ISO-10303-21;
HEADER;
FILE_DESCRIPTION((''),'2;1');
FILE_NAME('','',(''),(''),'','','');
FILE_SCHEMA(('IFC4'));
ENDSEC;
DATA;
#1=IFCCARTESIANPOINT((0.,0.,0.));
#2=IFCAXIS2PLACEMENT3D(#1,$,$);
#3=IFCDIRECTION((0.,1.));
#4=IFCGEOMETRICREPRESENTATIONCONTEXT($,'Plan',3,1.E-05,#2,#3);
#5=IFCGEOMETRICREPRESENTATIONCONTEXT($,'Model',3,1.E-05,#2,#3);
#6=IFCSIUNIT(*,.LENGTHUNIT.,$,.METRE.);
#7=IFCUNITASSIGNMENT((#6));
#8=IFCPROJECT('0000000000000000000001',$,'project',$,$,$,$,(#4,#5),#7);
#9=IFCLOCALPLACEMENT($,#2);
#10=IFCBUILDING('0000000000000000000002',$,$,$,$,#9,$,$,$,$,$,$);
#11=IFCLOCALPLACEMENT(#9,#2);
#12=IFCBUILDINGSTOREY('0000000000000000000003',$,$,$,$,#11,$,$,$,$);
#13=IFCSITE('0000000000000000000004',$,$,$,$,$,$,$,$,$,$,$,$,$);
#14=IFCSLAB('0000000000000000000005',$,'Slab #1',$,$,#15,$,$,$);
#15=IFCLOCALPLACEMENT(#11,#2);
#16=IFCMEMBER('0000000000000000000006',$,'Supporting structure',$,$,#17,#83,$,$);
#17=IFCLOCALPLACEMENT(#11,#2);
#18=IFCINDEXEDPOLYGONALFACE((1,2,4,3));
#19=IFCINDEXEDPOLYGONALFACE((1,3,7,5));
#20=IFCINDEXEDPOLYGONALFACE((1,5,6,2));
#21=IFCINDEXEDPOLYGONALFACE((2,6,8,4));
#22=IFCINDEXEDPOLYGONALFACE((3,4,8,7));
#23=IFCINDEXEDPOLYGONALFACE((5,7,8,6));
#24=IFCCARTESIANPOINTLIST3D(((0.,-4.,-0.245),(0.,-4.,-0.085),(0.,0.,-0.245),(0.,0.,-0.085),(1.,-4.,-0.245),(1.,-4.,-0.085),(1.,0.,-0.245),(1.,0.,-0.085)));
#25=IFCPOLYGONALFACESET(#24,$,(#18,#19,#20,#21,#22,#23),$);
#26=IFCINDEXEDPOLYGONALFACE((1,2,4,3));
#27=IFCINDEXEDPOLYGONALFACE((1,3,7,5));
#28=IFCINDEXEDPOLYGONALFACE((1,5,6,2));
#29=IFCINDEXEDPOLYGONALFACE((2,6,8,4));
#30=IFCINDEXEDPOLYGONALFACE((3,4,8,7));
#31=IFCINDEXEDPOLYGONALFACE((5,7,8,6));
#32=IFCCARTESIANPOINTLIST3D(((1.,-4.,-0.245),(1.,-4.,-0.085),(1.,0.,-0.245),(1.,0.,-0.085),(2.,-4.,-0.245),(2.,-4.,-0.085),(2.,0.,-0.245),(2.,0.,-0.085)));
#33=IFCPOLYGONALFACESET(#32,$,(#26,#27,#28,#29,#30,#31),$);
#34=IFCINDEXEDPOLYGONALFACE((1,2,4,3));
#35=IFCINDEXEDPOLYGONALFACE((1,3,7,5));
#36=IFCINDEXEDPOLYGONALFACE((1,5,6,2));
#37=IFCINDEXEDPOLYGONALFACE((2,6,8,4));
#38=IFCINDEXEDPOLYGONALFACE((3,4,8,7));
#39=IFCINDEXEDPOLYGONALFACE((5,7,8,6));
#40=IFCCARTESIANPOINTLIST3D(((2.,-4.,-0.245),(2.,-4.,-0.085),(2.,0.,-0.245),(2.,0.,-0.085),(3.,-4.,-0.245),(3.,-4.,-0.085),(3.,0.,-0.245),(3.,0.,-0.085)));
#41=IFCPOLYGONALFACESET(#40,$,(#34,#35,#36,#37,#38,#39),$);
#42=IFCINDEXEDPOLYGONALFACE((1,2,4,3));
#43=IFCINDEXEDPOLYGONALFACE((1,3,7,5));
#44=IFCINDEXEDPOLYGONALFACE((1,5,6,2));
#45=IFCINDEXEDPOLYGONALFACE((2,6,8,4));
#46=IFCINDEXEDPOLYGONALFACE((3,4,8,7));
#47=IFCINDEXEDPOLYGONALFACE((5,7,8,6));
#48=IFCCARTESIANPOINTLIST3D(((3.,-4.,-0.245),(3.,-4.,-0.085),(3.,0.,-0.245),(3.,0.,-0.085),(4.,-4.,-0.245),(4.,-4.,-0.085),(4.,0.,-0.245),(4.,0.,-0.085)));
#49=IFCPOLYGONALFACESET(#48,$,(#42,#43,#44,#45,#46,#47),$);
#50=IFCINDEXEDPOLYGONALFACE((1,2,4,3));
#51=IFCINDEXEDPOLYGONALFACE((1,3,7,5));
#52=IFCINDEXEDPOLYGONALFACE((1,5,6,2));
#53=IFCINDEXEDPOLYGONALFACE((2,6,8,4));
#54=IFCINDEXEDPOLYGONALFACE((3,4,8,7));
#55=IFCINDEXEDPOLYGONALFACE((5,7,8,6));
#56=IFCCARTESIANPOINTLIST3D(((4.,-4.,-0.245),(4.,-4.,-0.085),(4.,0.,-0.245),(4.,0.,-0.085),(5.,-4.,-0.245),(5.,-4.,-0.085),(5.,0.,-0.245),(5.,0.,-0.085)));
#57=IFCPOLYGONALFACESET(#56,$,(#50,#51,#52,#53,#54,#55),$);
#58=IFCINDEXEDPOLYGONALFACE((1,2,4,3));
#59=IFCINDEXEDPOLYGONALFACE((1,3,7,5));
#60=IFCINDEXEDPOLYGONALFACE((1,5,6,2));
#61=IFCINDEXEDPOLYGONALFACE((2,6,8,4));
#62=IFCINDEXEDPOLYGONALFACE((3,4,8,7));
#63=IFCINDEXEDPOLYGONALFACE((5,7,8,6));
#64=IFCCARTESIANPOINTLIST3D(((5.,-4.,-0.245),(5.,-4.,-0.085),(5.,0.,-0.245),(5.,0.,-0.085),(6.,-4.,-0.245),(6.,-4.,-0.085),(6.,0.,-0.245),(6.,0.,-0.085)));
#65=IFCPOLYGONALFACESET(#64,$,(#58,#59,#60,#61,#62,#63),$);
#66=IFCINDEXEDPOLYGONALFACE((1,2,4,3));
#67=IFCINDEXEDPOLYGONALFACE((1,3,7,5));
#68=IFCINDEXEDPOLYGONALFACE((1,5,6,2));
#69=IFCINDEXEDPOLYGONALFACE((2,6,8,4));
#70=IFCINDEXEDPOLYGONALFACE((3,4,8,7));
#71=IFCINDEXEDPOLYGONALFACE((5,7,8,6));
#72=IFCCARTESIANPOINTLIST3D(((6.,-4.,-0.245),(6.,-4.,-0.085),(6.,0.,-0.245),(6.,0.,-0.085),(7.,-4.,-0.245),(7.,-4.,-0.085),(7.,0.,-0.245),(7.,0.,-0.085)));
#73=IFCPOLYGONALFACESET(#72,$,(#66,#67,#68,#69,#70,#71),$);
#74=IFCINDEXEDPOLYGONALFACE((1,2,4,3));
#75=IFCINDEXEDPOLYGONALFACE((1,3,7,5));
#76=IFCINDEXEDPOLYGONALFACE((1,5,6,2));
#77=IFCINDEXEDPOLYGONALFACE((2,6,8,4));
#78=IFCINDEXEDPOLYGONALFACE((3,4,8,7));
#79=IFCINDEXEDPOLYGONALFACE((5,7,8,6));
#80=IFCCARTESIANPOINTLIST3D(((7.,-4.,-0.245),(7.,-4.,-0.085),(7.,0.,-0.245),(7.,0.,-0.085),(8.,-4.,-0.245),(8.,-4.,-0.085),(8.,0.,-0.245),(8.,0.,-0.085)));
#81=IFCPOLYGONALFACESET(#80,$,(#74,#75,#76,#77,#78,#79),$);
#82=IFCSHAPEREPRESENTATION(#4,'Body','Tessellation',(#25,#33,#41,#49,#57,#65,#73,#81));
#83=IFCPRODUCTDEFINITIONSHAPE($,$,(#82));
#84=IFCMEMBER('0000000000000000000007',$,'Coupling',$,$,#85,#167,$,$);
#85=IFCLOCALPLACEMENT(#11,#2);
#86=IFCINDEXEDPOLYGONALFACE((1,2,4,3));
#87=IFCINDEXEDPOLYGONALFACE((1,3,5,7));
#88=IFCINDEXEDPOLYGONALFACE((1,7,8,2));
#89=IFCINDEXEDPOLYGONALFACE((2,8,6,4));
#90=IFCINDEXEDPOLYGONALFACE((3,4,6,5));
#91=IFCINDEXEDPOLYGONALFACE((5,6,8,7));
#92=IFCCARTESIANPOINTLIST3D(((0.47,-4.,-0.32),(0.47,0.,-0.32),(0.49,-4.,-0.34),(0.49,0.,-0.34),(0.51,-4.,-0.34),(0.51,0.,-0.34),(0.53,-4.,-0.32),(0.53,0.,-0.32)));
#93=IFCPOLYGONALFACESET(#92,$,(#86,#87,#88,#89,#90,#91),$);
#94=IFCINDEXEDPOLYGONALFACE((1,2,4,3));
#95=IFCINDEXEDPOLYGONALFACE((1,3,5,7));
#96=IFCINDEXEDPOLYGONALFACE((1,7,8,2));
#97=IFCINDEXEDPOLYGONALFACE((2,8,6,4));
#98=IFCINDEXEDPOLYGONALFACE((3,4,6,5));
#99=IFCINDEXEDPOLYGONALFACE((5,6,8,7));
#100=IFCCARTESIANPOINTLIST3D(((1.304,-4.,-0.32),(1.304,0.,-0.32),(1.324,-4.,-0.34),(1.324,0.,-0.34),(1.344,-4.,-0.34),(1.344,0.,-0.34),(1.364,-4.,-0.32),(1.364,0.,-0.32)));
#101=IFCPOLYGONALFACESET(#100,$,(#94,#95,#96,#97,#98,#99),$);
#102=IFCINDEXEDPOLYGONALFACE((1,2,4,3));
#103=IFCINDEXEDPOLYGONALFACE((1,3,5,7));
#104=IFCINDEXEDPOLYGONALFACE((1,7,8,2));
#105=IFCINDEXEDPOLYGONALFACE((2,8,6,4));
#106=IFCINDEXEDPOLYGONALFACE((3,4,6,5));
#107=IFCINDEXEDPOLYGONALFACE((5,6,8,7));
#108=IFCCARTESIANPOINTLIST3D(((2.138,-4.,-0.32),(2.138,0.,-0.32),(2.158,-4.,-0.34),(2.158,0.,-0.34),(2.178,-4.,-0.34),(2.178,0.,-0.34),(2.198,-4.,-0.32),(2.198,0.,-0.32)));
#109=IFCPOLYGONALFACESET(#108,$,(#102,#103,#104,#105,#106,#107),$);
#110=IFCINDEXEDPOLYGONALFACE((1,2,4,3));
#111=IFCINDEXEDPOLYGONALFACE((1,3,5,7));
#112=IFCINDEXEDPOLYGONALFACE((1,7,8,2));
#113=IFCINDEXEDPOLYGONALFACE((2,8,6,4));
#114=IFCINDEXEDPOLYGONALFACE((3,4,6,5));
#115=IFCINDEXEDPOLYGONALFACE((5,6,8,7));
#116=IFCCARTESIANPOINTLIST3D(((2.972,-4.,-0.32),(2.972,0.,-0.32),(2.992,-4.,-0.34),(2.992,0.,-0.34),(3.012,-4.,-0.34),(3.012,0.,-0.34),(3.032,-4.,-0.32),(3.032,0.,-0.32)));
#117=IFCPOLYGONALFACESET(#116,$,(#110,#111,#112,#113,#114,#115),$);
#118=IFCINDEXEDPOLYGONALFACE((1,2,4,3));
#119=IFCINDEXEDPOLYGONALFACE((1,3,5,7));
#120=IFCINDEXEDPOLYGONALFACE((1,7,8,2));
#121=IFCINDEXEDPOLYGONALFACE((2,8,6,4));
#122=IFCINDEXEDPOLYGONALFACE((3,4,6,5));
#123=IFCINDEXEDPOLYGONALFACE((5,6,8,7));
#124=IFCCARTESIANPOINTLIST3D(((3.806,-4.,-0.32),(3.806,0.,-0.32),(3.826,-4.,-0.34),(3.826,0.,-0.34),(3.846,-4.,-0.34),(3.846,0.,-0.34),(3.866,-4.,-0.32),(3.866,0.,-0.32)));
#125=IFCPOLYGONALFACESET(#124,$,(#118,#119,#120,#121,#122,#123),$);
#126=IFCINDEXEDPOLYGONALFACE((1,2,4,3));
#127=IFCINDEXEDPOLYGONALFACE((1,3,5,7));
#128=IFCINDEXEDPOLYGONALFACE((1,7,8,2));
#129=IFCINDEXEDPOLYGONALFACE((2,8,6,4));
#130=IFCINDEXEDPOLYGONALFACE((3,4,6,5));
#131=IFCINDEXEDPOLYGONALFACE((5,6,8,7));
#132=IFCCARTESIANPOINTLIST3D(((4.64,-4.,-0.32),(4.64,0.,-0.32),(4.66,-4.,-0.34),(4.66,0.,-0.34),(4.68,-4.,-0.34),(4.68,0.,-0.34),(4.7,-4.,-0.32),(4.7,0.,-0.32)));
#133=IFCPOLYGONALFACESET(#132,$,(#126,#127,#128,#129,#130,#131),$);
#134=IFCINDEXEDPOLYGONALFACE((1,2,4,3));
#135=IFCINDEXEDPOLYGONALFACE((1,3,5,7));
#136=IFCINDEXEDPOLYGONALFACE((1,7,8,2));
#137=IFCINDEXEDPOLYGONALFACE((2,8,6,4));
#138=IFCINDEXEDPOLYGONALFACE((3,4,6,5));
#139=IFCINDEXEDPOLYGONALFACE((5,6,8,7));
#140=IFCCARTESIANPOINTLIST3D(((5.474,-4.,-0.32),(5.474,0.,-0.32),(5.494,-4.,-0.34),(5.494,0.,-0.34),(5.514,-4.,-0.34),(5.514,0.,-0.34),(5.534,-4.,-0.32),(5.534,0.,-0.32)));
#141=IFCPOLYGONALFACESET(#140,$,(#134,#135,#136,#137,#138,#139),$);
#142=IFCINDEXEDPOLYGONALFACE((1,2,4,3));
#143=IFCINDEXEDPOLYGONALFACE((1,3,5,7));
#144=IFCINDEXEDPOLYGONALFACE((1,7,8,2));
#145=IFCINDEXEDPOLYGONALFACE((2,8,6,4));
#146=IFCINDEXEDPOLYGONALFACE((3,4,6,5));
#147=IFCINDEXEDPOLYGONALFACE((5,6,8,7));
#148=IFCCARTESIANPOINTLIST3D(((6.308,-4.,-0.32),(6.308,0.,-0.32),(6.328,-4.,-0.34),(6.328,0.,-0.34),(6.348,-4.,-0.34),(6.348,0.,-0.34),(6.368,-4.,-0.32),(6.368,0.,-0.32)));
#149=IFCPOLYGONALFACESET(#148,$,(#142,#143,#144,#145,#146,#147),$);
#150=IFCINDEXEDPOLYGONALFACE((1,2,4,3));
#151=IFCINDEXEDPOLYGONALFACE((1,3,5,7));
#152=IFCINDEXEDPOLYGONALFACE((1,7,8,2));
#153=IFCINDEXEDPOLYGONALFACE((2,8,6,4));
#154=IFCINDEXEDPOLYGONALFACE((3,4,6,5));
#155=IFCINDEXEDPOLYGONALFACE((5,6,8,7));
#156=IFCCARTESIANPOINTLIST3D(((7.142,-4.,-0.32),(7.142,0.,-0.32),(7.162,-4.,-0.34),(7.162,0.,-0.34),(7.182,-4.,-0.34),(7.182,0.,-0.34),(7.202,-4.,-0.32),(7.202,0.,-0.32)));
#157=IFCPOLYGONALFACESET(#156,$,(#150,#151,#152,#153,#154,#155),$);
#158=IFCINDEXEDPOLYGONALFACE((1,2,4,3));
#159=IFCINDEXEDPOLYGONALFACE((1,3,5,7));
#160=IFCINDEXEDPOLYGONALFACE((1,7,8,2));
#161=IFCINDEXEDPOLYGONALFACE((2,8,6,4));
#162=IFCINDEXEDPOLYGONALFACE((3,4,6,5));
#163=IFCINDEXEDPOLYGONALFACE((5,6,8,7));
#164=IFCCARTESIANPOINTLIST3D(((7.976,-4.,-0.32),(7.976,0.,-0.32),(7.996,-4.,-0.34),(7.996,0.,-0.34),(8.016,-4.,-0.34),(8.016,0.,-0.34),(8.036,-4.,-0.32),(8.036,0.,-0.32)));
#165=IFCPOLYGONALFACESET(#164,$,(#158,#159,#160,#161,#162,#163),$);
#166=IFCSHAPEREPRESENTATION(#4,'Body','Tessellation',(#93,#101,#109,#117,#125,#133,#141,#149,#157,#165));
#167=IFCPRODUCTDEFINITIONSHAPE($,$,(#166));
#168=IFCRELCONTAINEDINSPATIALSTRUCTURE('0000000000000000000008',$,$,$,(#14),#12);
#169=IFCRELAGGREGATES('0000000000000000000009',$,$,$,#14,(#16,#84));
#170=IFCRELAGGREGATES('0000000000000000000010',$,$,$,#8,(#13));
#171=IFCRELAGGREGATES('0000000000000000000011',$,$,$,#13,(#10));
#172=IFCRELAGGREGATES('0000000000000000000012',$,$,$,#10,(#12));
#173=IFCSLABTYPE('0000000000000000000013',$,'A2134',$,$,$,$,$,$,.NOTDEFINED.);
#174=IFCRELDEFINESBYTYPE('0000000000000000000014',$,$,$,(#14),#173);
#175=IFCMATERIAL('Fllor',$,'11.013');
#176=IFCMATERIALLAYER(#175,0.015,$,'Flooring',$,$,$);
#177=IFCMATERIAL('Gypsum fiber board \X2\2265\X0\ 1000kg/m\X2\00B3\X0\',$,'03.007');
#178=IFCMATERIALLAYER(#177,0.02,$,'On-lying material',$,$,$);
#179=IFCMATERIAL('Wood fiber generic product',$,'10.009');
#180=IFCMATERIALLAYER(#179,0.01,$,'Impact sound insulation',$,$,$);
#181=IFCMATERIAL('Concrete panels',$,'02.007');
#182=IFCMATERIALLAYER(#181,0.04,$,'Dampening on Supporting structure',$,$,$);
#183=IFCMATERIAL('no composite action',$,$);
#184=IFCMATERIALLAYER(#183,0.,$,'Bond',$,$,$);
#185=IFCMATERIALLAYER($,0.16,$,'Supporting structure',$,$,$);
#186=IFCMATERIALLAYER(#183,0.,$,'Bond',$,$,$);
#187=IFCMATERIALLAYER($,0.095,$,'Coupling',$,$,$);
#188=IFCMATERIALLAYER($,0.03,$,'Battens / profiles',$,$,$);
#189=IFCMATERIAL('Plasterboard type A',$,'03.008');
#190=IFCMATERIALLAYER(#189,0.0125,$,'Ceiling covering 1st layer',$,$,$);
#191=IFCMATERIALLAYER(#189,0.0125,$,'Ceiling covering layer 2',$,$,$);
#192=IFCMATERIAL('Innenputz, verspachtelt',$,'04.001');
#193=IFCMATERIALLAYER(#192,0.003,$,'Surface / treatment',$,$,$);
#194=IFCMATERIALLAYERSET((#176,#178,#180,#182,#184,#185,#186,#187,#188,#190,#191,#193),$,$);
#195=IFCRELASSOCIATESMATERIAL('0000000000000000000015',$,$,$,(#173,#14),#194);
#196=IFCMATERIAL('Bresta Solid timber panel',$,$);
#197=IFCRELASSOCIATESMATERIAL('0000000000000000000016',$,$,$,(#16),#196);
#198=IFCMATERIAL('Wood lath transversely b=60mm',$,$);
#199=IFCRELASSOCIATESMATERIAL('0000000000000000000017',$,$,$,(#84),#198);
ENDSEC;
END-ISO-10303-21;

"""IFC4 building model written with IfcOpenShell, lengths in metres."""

from ifc_helpers import new_model, si_unit, direction, frame, frame_2d, origin, place, context, project, spatial, polyline, rectangle, outline, extrude, material, layer, layer_set, type_object, element, aggregate, save


model = new_model("IFC4")

# Units and contexts
plan_context = context("Plan", 3, precision=1e-05, world=origin(), true_north=direction((0.0, 1.0)))
model_context = context("Model", 3, precision=1e-05, world=origin(), true_north=direction((0.0, 1.0)))
ifc_project = project(units=[si_unit("LENGTHUNIT", "METRE")], contexts=[plan_context, model_context])

# Site, building, storey
site = spatial("IfcSite", under=ifc_project)
building_placement = place(None, origin())
building = spatial("IfcBuilding", under=site, at=building_placement)
storey_placement = place(building_placement, origin())
storey = spatial("IfcBuildingStorey", under=building, at=storey_placement)

# Slab, members
ifc_material_1 = material(Name="Fllor", Category="11.013")
ifc_layer_1 = layer(ifc_material_1, 0.015, Name="Flooring")
ifc_material_2 = material(Name="Gypsum fiber board ≥ 1000kg/m³", Category="03.007")
ifc_layer_2 = layer(ifc_material_2, 0.02, Name="On-lying material")
ifc_material_3 = material(Name="Wood fiber generic product", Category="10.009")
ifc_layer_3 = layer(ifc_material_3, 0.01, Name="Impact sound insulation")
ifc_material_4 = material(Name="Concrete panels", Category="02.007")
ifc_layer_4 = layer(ifc_material_4, 0.04, Name="Dampening on Supporting structure")
ifc_material_5 = material(Name="no composite action")
ifc_layer_5 = layer(ifc_material_5, 0.0, Name="Bond")
ifc_layer_6 = layer(None, 0.16, Name="Supporting structure")
ifc_layer_7 = layer(ifc_material_5, 0.0, Name="Bond")
ifc_layer_8 = layer(None, 0.095, Name="Coupling")
ifc_layer_9 = layer(None, 0.03, Name="Battens / profiles")
ifc_material_6 = material(Name="Plasterboard type A", Category="03.008")
ifc_layer_10 = layer(ifc_material_6, 0.0125, Name="Ceiling covering 1st layer")
ifc_layer_11 = layer(ifc_material_6, 0.0125, Name="Ceiling covering layer 2")
ifc_material_7 = material(Name="Innenputz, verspachtelt", Category="04.001")
ifc_layer_12 = layer(ifc_material_7, 0.003, Name="Surface / treatment")
ifc_layer_set = layer_set([ifc_layer_1, ifc_layer_2, ifc_layer_3, ifc_layer_4, ifc_layer_5, ifc_layer_6, ifc_layer_7, ifc_layer_8, ifc_layer_9, ifc_layer_10, ifc_layer_11, ifc_layer_12])
slab_type = type_object("IfcSlabType", Name="A2134", PredefinedType="NOTDEFINED", material=ifc_layer_set)
slab_placement = place(None, frame((0.0, 0.0, 0.0), z_axis=(0.0, 0.0, -1.0), x_axis=(1.0, 0.0, 0.0)))
slab = element("IfcSlab", 1, at=slab_placement, inside=storey, type_object=slab_type, material=ifc_layer_set, Name="Slab #1")
ifc_material_8 = material(Name="Bresta Solid timber panel")
member_1_placement = place(slab_placement, origin())
member_1 = element("IfcMember", 2, at=member_1_placement, material=ifc_material_8, Name="Supporting structure", context=plan_context, shape_type="SweptSolid", body=[
    extrude(rectangle(XDim=1.0, YDim=0.16, at=frame_2d((0.5, 0.08), x_axis=(1.0, 0.0))), frame((0.0, 4.0, 0.085), z_axis=(0.0, -1.0, 0.0), x_axis=(1.0, 0.0, 0.0)), (0.0, 0.0, 1.0), 4.0),
    extrude(rectangle(XDim=1.0, YDim=0.16, at=frame_2d((0.5, 0.08), x_axis=(1.0, 0.0))), frame((1.0, 4.0, 0.085), z_axis=(0.0, -1.0, 0.0), x_axis=(1.0, 0.0, 0.0)), (0.0, 0.0, 1.0), 4.0),
    extrude(rectangle(XDim=1.0, YDim=0.16, at=frame_2d((0.5, 0.08), x_axis=(1.0, 0.0))), frame((2.0, 4.0, 0.085), z_axis=(0.0, -1.0, 0.0), x_axis=(1.0, 0.0, 0.0)), (0.0, 0.0, 1.0), 4.0),
    extrude(rectangle(XDim=1.0, YDim=0.16, at=frame_2d((0.5, 0.08), x_axis=(1.0, 0.0))), frame((3.0, 4.0, 0.085), z_axis=(0.0, -1.0, 0.0), x_axis=(1.0, 0.0, 0.0)), (0.0, 0.0, 1.0), 4.0),
    extrude(rectangle(XDim=1.0, YDim=0.16, at=frame_2d((0.5, 0.08), x_axis=(1.0, 0.0))), frame((4.0, 4.0, 0.085), z_axis=(0.0, -1.0, 0.0), x_axis=(1.0, 0.0, 0.0)), (0.0, 0.0, 1.0), 4.0),
    extrude(rectangle(XDim=1.0, YDim=0.16, at=frame_2d((0.5, 0.08), x_axis=(1.0, 0.0))), frame((5.0, 4.0, 0.085), z_axis=(0.0, -1.0, 0.0), x_axis=(1.0, 0.0, 0.0)), (0.0, 0.0, 1.0), 4.0),
    extrude(rectangle(XDim=1.0, YDim=0.16, at=frame_2d((0.5, 0.08), x_axis=(1.0, 0.0))), frame((6.0, 4.0, 0.085), z_axis=(0.0, -1.0, 0.0), x_axis=(1.0, 0.0, 0.0)), (0.0, 0.0, 1.0), 4.0),
    extrude(rectangle(XDim=1.0, YDim=0.16, at=frame_2d((0.5, 0.08), x_axis=(1.0, 0.0))), frame((7.0, 4.0, 0.085), z_axis=(0.0, -1.0, 0.0), x_axis=(1.0, 0.0, 0.0)), (0.0, 0.0, 1.0), 4.0),
])
ifc_material_9 = material(Name="Wood lath transversely b=60mm")
member_2_placement = place(slab_placement, origin())
member_2 = element("IfcMember", 3, at=member_2_placement, material=ifc_material_9, Name="Coupling", context=plan_context, shape_type="SweptSolid", body=[
    extrude(outline(polyline([(0.0, 0.0), (0.06, 0.0), (0.04, 0.02), (0.02, 0.02), (0.0, 0.0)])), frame((0.47, 4.0, 0.32), z_axis=(0.0, -1.0, 0.0), x_axis=(1.0, 0.0, 0.0)), (0.0, 0.0, 1.0), 4.0),
    extrude(outline(polyline([(0.0, 0.0), (0.06, 0.0), (0.04, 0.02), (0.02, 0.02), (0.0, 0.0)])), frame((1.304, 4.0, 0.32), z_axis=(0.0, -1.0, 0.0), x_axis=(1.0, 0.0, 0.0)), (0.0, 0.0, 1.0), 4.0),
    extrude(outline(polyline([(0.0, 0.0), (0.06, 0.0), (0.04, 0.02), (0.02, 0.02), (0.0, 0.0)])), frame((2.138, 4.0, 0.32), z_axis=(0.0, -1.0, 0.0), x_axis=(1.0, 0.0, 0.0)), (0.0, 0.0, 1.0), 4.0),
    extrude(outline(polyline([(0.0, 0.0), (0.06, 0.0), (0.04, 0.02), (0.02, 0.02), (0.0, 0.0)])), frame((2.972, 4.0, 0.32), z_axis=(0.0, -1.0, 0.0), x_axis=(1.0, 0.0, 0.0)), (0.0, 0.0, 1.0), 4.0),
    extrude(outline(polyline([(0.0, 0.0), (0.06, 0.0), (0.04, 0.02), (0.02, 0.02), (0.0, 0.0)])), frame((3.806, 4.0, 0.32), z_axis=(0.0, -1.0, 0.0), x_axis=(1.0, 0.0, 0.0)), (0.0, 0.0, 1.0), 4.0),
    extrude(outline(polyline([(0.0, 0.0), (0.06, 0.0), (0.04, 0.02), (0.02, 0.02), (0.0, 0.0)])), frame((4.64, 4.0, 0.32), z_axis=(0.0, -1.0, 0.0), x_axis=(1.0, 0.0, 0.0)), (0.0, 0.0, 1.0), 4.0),
    extrude(outline(polyline([(0.0, 0.0), (0.06, 0.0), (0.04, 0.02), (0.02, 0.02), (0.0, 0.0)])), frame((5.474, 4.0, 0.32), z_axis=(0.0, -1.0, 0.0), x_axis=(1.0, 0.0, 0.0)), (0.0, 0.0, 1.0), 4.0),
    extrude(outline(polyline([(0.0, 0.0), (0.06, 0.0), (0.04, 0.02), (0.02, 0.02), (0.0, 0.0)])), frame((6.308, 4.0, 0.32), z_axis=(0.0, -1.0, 0.0), x_axis=(1.0, 0.0, 0.0)), (0.0, 0.0, 1.0), 4.0),
    extrude(outline(polyline([(0.0, 0.0), (0.06, 0.0), (0.04, 0.02), (0.02, 0.02), (0.0, 0.0)])), frame((7.142, 4.0, 0.32), z_axis=(0.0, -1.0, 0.0), x_axis=(1.0, 0.0, 0.0)), (0.0, 0.0, 1.0), 4.0),
    extrude(outline(polyline([(0.0, 0.0), (0.06, 0.0), (0.04, 0.02), (0.02, 0.02), (0.0, 0.0)])), frame((7.976, 4.0, 0.32), z_axis=(0.0, -1.0, 0.0), x_axis=(1.0, 0.0, 0.0)), (0.0, 0.0, 1.0), 4.0),
])
aggregate(slab, [member_1, member_2])

save(model, "model.ifc")
